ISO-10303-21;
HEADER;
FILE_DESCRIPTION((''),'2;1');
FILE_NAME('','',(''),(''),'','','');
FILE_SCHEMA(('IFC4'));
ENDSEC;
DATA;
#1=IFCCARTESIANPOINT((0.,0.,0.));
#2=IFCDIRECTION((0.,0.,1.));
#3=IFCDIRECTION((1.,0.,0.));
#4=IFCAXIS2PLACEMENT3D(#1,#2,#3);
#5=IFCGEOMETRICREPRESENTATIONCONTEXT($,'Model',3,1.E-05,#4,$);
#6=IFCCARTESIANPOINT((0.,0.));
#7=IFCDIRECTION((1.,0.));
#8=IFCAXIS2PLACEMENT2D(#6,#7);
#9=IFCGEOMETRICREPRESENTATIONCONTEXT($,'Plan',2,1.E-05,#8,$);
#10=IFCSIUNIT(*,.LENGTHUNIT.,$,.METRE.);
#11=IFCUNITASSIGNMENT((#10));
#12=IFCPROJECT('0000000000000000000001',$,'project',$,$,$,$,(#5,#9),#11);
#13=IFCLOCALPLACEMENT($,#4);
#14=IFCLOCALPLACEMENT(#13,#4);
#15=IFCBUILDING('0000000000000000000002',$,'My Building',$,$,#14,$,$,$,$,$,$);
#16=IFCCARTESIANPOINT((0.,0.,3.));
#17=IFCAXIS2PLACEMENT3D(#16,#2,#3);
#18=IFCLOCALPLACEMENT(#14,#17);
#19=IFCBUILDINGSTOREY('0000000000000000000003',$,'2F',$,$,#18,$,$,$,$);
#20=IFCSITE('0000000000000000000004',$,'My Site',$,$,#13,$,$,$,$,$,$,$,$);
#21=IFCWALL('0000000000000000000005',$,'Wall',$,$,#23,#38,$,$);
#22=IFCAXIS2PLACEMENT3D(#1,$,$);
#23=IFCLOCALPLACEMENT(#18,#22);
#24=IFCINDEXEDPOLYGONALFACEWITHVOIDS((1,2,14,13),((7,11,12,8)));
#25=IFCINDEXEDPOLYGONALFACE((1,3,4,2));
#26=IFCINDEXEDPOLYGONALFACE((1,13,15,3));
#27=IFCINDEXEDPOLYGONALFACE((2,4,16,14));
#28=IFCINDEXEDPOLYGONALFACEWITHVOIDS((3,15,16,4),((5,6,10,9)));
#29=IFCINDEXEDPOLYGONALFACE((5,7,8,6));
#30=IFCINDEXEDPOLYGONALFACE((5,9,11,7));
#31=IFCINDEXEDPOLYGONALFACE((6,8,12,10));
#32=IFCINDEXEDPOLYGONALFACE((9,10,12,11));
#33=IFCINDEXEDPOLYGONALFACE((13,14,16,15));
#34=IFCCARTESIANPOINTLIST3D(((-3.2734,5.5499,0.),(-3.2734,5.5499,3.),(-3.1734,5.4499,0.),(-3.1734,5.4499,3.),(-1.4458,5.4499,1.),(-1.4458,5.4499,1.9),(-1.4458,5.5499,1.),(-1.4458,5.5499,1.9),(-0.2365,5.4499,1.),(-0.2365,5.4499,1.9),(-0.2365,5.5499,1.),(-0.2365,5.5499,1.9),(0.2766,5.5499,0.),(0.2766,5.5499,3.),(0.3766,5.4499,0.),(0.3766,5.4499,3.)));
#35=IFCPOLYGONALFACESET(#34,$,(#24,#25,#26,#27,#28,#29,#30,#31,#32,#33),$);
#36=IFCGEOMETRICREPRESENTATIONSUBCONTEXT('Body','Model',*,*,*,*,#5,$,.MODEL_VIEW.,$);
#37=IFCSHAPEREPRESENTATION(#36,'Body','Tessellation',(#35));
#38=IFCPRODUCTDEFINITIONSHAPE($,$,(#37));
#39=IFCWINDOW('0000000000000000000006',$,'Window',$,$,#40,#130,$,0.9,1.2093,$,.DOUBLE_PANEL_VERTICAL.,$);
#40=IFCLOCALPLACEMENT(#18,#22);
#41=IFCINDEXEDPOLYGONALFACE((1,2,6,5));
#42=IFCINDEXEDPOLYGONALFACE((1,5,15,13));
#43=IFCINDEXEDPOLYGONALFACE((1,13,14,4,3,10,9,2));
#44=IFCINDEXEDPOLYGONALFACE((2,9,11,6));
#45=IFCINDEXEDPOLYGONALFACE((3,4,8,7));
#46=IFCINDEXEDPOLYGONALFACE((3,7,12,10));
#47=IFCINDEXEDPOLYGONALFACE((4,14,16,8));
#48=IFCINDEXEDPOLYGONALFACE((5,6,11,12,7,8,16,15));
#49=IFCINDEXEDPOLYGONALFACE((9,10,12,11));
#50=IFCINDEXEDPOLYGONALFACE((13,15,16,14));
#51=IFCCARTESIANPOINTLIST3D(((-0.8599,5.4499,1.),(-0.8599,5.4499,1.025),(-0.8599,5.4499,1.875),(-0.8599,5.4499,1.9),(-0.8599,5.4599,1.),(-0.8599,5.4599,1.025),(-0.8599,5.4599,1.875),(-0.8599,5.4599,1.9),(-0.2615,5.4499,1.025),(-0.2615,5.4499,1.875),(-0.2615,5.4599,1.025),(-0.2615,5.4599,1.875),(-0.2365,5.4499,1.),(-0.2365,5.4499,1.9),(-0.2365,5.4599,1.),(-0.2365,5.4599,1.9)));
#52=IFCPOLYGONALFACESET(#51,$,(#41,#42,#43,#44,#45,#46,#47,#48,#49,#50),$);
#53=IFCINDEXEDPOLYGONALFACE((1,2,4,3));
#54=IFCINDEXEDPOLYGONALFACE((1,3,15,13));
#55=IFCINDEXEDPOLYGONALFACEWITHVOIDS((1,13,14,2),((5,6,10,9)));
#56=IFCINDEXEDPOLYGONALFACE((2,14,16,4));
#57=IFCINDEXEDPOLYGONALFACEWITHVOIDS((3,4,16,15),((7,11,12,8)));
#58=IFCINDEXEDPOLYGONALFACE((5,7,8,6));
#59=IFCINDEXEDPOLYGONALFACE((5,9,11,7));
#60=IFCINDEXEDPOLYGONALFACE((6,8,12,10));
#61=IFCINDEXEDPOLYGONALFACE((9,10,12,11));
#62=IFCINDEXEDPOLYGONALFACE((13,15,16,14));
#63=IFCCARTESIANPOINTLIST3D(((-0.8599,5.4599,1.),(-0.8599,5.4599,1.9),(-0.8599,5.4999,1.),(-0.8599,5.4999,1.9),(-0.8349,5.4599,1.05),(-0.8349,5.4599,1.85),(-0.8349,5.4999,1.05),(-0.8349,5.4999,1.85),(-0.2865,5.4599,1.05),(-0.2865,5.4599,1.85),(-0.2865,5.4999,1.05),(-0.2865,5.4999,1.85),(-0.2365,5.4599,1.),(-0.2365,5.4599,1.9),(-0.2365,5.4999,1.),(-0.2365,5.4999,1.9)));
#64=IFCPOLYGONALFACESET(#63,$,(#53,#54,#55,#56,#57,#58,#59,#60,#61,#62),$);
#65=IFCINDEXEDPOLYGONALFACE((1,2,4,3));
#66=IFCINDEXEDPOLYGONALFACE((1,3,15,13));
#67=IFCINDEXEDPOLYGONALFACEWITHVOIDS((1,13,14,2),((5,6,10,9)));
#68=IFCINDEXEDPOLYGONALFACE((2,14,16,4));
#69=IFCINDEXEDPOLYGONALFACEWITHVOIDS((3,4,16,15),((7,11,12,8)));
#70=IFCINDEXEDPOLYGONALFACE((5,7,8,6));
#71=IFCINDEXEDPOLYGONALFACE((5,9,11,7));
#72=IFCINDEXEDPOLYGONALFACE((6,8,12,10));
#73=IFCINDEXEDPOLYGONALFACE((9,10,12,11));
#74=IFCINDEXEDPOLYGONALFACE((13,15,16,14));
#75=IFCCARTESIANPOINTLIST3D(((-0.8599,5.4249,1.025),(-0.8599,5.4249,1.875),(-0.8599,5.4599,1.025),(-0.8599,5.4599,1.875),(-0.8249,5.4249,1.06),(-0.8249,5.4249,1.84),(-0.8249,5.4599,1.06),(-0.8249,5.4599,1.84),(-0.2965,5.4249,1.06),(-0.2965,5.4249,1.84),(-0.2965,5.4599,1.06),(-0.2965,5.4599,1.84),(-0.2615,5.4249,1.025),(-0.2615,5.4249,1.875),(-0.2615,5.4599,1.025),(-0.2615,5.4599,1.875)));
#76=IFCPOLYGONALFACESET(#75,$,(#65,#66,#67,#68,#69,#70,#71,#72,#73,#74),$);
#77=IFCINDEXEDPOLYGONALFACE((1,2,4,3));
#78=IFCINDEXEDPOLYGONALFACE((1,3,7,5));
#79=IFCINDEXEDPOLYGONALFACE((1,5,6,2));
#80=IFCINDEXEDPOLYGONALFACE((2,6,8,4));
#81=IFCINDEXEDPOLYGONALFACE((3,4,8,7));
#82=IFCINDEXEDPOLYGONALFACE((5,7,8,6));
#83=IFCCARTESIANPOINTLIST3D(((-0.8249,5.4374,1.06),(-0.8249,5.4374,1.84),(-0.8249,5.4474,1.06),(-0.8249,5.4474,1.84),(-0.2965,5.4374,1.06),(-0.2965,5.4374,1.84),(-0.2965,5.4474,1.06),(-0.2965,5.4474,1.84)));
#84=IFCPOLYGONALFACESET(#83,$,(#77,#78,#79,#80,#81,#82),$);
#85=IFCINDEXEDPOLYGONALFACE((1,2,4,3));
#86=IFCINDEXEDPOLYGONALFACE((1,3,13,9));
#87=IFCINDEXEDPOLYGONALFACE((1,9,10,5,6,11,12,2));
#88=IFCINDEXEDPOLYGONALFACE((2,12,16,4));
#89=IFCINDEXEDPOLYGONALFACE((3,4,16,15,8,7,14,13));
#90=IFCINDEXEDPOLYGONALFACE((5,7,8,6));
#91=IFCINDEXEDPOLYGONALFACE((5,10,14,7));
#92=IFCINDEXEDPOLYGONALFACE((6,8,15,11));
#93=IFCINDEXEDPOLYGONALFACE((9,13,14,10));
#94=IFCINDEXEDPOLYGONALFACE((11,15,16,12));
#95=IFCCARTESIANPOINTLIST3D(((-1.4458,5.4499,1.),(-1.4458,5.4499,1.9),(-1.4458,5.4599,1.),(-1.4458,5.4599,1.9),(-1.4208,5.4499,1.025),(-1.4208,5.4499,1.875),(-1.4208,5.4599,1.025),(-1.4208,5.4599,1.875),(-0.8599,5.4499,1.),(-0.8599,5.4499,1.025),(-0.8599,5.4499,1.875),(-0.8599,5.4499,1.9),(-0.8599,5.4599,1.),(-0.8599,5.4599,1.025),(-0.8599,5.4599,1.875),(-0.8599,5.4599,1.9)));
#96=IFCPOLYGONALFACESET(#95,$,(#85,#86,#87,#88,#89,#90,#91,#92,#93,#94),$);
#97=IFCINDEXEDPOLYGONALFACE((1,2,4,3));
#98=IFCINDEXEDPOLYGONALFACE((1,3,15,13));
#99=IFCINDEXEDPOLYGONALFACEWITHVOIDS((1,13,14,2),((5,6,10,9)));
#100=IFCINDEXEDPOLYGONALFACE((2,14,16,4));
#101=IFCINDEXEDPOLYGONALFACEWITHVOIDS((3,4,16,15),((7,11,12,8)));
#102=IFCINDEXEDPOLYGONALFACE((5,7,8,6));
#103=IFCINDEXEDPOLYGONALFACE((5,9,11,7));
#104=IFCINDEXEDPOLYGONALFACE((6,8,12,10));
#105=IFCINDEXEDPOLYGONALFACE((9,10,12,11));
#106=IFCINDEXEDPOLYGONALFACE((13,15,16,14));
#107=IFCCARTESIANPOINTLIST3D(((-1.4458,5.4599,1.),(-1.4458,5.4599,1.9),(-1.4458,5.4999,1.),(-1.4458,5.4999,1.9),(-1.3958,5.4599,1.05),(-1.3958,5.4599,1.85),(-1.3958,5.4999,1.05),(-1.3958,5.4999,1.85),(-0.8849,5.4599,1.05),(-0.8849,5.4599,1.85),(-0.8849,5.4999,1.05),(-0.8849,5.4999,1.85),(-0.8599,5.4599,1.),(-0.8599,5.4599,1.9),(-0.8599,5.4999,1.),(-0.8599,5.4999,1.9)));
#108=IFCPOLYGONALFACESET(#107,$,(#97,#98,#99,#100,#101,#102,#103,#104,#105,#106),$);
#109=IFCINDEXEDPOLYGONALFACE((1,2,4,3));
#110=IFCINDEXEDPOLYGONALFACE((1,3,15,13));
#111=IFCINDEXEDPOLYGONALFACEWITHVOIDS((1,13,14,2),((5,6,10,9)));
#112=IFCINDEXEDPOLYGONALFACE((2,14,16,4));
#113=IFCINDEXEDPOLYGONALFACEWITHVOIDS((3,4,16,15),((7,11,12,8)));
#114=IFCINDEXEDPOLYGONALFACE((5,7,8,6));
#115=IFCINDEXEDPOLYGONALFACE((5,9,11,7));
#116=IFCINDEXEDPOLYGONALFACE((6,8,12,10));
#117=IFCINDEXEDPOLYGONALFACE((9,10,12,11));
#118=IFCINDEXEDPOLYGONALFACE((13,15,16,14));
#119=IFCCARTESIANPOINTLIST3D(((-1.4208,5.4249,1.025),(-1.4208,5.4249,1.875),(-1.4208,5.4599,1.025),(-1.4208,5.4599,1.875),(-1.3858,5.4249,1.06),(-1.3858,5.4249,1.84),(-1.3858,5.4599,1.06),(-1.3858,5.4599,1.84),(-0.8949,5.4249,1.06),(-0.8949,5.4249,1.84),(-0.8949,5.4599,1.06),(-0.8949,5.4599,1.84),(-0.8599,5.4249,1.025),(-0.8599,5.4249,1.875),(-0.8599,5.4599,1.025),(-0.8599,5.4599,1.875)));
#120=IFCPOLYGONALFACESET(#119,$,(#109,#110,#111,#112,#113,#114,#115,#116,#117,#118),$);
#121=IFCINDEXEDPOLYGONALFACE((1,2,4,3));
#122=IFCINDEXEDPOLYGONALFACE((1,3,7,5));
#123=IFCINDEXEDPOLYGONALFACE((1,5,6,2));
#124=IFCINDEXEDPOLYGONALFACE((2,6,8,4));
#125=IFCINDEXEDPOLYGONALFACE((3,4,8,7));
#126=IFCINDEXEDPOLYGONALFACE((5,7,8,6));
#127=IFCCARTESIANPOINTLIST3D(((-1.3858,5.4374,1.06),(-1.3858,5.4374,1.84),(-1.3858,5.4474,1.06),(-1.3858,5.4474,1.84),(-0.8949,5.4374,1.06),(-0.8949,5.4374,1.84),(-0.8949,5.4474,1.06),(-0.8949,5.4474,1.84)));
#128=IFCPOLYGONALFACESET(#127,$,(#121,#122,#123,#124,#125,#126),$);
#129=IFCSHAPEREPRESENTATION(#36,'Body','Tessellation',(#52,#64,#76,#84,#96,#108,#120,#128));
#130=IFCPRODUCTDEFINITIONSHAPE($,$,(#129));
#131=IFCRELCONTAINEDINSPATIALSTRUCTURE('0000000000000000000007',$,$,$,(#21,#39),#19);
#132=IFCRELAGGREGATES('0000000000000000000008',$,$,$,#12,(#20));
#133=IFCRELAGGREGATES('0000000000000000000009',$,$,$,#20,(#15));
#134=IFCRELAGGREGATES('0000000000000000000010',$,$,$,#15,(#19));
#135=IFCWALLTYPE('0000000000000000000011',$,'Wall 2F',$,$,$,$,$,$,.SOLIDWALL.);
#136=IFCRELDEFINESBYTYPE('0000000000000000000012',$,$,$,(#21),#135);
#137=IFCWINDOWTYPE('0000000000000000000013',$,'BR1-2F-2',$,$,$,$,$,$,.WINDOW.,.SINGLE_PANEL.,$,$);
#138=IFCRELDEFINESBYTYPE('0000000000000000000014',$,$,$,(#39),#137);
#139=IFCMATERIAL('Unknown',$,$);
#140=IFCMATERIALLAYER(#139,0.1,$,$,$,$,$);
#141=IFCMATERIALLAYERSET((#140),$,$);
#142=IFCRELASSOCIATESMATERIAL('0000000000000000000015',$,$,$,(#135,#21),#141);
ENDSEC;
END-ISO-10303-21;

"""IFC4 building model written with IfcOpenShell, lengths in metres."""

from ifc_helpers import new_model, entity, si_unit, frame, origin_with_axes, origin_2d_with_axis, place, context, subcontext, project, spatial, line, indexed_curve, outline, extrude, shape, source, transform, mapped, material, layer, layer_set, layer_usage, type_object, type_shapes, element, fill, save


model = new_model("IFC4")

# Units and contexts
model_context = context("Model", 3, precision=1e-05, world=origin_with_axes())
plan_context = context("Plan", 2, precision=1e-05, world=origin_2d_with_axis())
body_context_1 = subcontext(model_context, "Body", "Model", "MODEL_VIEW")
body_context_2 = subcontext(plan_context, "Body", "Plan", "PLAN_VIEW")
ifc_project = project(units=[si_unit("LENGTHUNIT", "METRE")], contexts=[model_context, plan_context])

# Site, building, storey
site_placement = place(None, origin_with_axes())
site = spatial("IfcSite", under=ifc_project, at=site_placement, Name="My Site")
building_placement = place(site_placement, origin_with_axes())
building = spatial("IfcBuilding", under=site, at=building_placement, Name="My Building")
storey_placement = place(building_placement, frame((0.0, 0.0, 3.0), z_axis=(0.0, 0.0, 1.0), x_axis=(1.0, 0.0, 0.0)))
storey = spatial("IfcBuildingStorey", under=building, at=storey_placement, Name="2F")

# Shared definitions
ifc_material = material(Name="Unknown")

# Shared definitions
ifc_layer = layer(ifc_material, 0.1)
ifc_layer_set = layer_set([ifc_layer])
wall_type = type_object("IfcWallType", Name="Wall 2F", PredefinedType="SOLIDWALL", material=ifc_layer_set)

# Wall, opening, window
ifc_layer_usage_1 = layer_usage(ifc_layer_set, "AXIS2", "POSITIVE", 0.0)
wall_1_placement = place(storey_placement, frame((0.2766, 5.5499, 0.0), z_axis=(0.0, 0.0, 1.0), x_axis=(-1.0, 0.0, 0.0)))
wall_1 = element("IfcWall", 1, at=wall_1_placement, inside=storey, type_object=wall_type, material=ifc_layer_usage_1, Name="Wall", context=body_context_1, shape_type="SweptSolid", body=[
    extrude(outline(indexed_curve([(0.0, 0.0), (-0.1, 0.1), (3.45, 0.1), (3.55, 0.0)], segments=[line(1, 2, 3, 4, 1)])), origin_with_axes(), (0.0, 0.0, 1.0), 3.0),
])
shared_shape_1 = source(origin_with_axes(), body_context_1, "Body", "SweptSolid", [
    extrude(outline(indexed_curve([(0.0, 0.0), (1.2093, 0.0), (1.2093, 0.9), (0.0, 0.9)], segments=[line(1, 2, 3, 4, 1)])), frame((0.0, -0.6, 0.0), z_axis=(0.0, -1.0, 0.0), x_axis=(1.0, 0.0, 0.0)), (0.0, 0.0, -1.0), 1.2),
])
opening_1_placement = place(wall_1_placement, frame((0.5131, 0.0, 1.0), z_axis=(0.0, 0.0, 1.0), x_axis=(1.0, 0.0, 0.0)))
opening_1 = element("IfcOpeningElement", 2, at=opening_1_placement, cuts=wall_1, PredefinedType="OPENING", context=body_context_1, shape_type="MappedRepresentation", body=[
    mapped(shared_shape_1, transform((0.0, 0.0, 0.0), x_axis=(1.0, 0.0, 0.0), y_axis=(0.0, 1.0, 0.0), z_axis=(0.0, 0.0, 1.0), scale=1.0)),
])
window_type_1 = type_object("IfcWindowType", Name="BR1-2F-2", PartitioningType="SINGLE_PANEL", PredefinedType="WINDOW")
shared_shape_2 = source(origin_with_axes(), body_context_1, "Body", "SweptSolid", [
    extrude(outline(indexed_curve([(0.6234, 0.0), (0.0, 0.0), (0.0, 0.9), (0.6234, 0.9), (0.6234, 0.875), (0.025, 0.875), (0.025, 0.025), (0.6234, 0.025)], segments=[line(1, 2, 3, 4, 5, 6, 7, 8, 1)])), frame((0.0, 0.09, 0.0), z_axis=(0.0, -1.0, 0.0), x_axis=(1.0, 0.0, 0.0)), (0.0, 0.0, -1.0), 0.01),
    extrude(outline(indexed_curve([(0.0, 0.0), (0.6234, 0.0), (0.6234, 0.9), (0.0, 0.9)], segments=[line(1, 2, 3, 4, 1)]), holes=[indexed_curve([(0.05, 0.05), (0.5984, 0.05), (0.5984, 0.85), (0.05, 0.85)], segments=[line(1, 2, 3, 4, 1)])]), frame((0.0, 0.05, 0.0), z_axis=(0.0, -1.0, 0.0), x_axis=(1.0, 0.0, 0.0)), (0.0, 0.0, -1.0), 0.04),
    extrude(outline(indexed_curve([(0.0, 0.0), (0.5984, 0.0), (0.5984, 0.85), (0.0, 0.85)], segments=[line(1, 2, 3, 4, 1)]), holes=[indexed_curve([(0.035, 0.035), (0.5634, 0.035), (0.5634, 0.815), (0.035, 0.815)], segments=[line(1, 2, 3, 4, 1)])]), frame((0.025, 0.09, 0.025), z_axis=(0.0, -1.0, 0.0), x_axis=(1.0, 0.0, 0.0)), (0.0, 0.0, -1.0), 0.035),
    extrude(outline(indexed_curve([(0.035, 0.035), (0.5634, 0.035), (0.5634, 0.815), (0.035, 0.815)], segments=[line(1, 2, 3, 4, 1)])), frame((0.025, 0.1025, 0.025), z_axis=(0.0, -1.0, 0.0), x_axis=(1.0, 0.0, 0.0)), (0.0, 0.0, -1.0), 0.01),
    extrude(outline(indexed_curve([(0.0, 0.9), (0.5859, 0.9), (0.5859, 0.0), (0.0, 0.0), (0.0, 0.025), (0.5609, 0.025), (0.5609, 0.875), (0.0, 0.875)], segments=[line(1, 2, 3, 4, 5, 6, 7, 8, 1)])), frame((0.6234, 0.09, 0.0), z_axis=(0.0, -1.0, 0.0), x_axis=(1.0, 0.0, 0.0)), (0.0, 0.0, -1.0), 0.01),
    extrude(outline(indexed_curve([(0.0, 0.0), (0.5859, 0.0), (0.5859, 0.9), (0.0, 0.9)], segments=[line(1, 2, 3, 4, 1)]), holes=[indexed_curve([(0.025, 0.05), (0.5359, 0.05), (0.5359, 0.85), (0.025, 0.85)], segments=[line(1, 2, 3, 4, 1)])]), frame((0.6234, 0.05, 0.0), z_axis=(0.0, -1.0, 0.0), x_axis=(1.0, 0.0, 0.0)), (0.0, 0.0, -1.0), 0.04),
    extrude(outline(indexed_curve([(0.0, 0.0), (0.5609, 0.0), (0.5609, 0.85), (0.0, 0.85)], segments=[line(1, 2, 3, 4, 1)]), holes=[indexed_curve([(0.035, 0.035), (0.5259, 0.035), (0.5259, 0.815), (0.035, 0.815)], segments=[line(1, 2, 3, 4, 1)])]), frame((0.6234, 0.09, 0.025), z_axis=(0.0, -1.0, 0.0), x_axis=(1.0, 0.0, 0.0)), (0.0, 0.0, -1.0), 0.035),
    extrude(outline(indexed_curve([(0.035, 0.035), (0.5259, 0.035), (0.5259, 0.815), (0.035, 0.815)], segments=[line(1, 2, 3, 4, 1)])), frame((0.6234, 0.1025, 0.025), z_axis=(0.0, -1.0, 0.0), x_axis=(1.0, 0.0, 0.0)), (0.0, 0.0, -1.0), 0.01),
])
shared_shape_3 = source(origin_with_axes(), body_context_2, "Body", "Curve2D", [
    entity("IfcIndexedPolyCurve", entity("IfcCartesianPointList2D", [[0.05, 0.05], [0.5984, 0.05]])),
    entity("IfcIndexedPolyCurve", entity("IfcCartesianPointList2D", [[0.0, 0.1], [0.025, 0.1], [0.025, 0.09], [0.05, 0.09], [0.05, 0.05], [0.0, 0.05]]), [entity("IfcLineIndex", [1, 2, 3, 4, 5, 6, 1])]),
    entity("IfcIndexedPolyCurve", entity("IfcCartesianPointList2D", [[0.6234, 0.1], [0.6234, 0.1], [0.6234, 0.09], [0.5984, 0.09], [0.5984, 0.05], [0.6234, 0.05]])),
    entity("IfcIndexedPolyCurve", entity("IfcCartesianPointList2D", [[0.025, 0.09], [0.06, 0.09], [0.06, 0.125], [0.025, 0.125]]), [entity("IfcLineIndex", [1, 2, 3, 4, 1])]),
    entity("IfcIndexedPolyCurve", entity("IfcCartesianPointList2D", [[0.6234, 0.09], [0.5884, 0.09], [0.5884, 0.125], [0.6234, 0.125]]), [entity("IfcLineIndex", [1, 2, 3, 4, 1])]),
    entity("IfcIndexedPolyCurve", entity("IfcCartesianPointList2D", [[0.06, 0.09], [0.5884, 0.09]])),
    entity("IfcIndexedPolyCurve", entity("IfcCartesianPointList2D", [[0.06, 0.125], [0.5884, 0.125]])),
    entity("IfcIndexedPolyCurve", entity("IfcCartesianPointList2D", [[0.06, 0.1075], [0.5884, 0.1075]])),
    entity("IfcIndexedPolyCurve", entity("IfcCartesianPointList2D", [[0.6484, 0.05], [1.1593, 0.05]])),
    entity("IfcIndexedPolyCurve", entity("IfcCartesianPointList2D", [[0.6234, 0.1], [0.6234, 0.1], [0.6234, 0.09], [0.6484, 0.09], [0.6484, 0.05], [0.6234, 0.05]])),
    entity("IfcIndexedPolyCurve", entity("IfcCartesianPointList2D", [[1.2093, 0.1], [1.1843, 0.1], [1.1843, 0.09], [1.1593, 0.09], [1.1593, 0.05], [1.2093, 0.05]]), [entity("IfcLineIndex", [1, 2, 3, 4, 5, 6, 1])]),
    entity("IfcIndexedPolyCurve", entity("IfcCartesianPointList2D", [[0.6234, 0.09], [0.6584, 0.09], [0.6584, 0.125], [0.6234, 0.125]]), [entity("IfcLineIndex", [1, 2, 3, 4, 1])]),
    entity("IfcIndexedPolyCurve", entity("IfcCartesianPointList2D", [[1.1843, 0.09], [1.1493, 0.09], [1.1493, 0.125], [1.1843, 0.125]]), [entity("IfcLineIndex", [1, 2, 3, 4, 1])]),
    entity("IfcIndexedPolyCurve", entity("IfcCartesianPointList2D", [[0.6584, 0.09], [1.1493, 0.09]])),
    entity("IfcIndexedPolyCurve", entity("IfcCartesianPointList2D", [[0.6584, 0.125], [1.1493, 0.125]])),
    entity("IfcIndexedPolyCurve", entity("IfcCartesianPointList2D", [[0.6584, 0.1075], [1.1493, 0.1075]])),
])
type_shapes(window_type_1, [shared_shape_2, shared_shape_3])
window_1_placement = place(opening_1_placement, frame((0.0, 0.0, 0.0), z_axis=(0.0, 0.0, 1.0), x_axis=(1.0, 0.0, 0.0)))
window_1 = element("IfcWindow", 3, at=window_1_placement, inside=storey, type_object=window_type_1, Name="Window", OverallHeight=0.9, OverallWidth=1.2093, PartitioningType="DOUBLE_PANEL_VERTICAL", shapes=[
    shape(body_context_1, "Body", "MappedRepresentation", [mapped(shared_shape_2, transform((0.0, 0.0, 0.0), x_axis=(1.0, 0.0, 0.0), y_axis=(0.0, 1.0, 0.0), z_axis=(0.0, 0.0, 1.0), scale=1.0))]),
    shape(body_context_2, "Body", "MappedRepresentation", [mapped(shared_shape_3, transform((0.0, 0.0, 0.0), x_axis=(1.0, 0.0, 0.0), y_axis=(0.0, 1.0, 0.0), z_axis=(0.0, 0.0, 1.0), scale=1.0))]),
])
fill(opening_1, window_1)

save(model, "model.ifc")
